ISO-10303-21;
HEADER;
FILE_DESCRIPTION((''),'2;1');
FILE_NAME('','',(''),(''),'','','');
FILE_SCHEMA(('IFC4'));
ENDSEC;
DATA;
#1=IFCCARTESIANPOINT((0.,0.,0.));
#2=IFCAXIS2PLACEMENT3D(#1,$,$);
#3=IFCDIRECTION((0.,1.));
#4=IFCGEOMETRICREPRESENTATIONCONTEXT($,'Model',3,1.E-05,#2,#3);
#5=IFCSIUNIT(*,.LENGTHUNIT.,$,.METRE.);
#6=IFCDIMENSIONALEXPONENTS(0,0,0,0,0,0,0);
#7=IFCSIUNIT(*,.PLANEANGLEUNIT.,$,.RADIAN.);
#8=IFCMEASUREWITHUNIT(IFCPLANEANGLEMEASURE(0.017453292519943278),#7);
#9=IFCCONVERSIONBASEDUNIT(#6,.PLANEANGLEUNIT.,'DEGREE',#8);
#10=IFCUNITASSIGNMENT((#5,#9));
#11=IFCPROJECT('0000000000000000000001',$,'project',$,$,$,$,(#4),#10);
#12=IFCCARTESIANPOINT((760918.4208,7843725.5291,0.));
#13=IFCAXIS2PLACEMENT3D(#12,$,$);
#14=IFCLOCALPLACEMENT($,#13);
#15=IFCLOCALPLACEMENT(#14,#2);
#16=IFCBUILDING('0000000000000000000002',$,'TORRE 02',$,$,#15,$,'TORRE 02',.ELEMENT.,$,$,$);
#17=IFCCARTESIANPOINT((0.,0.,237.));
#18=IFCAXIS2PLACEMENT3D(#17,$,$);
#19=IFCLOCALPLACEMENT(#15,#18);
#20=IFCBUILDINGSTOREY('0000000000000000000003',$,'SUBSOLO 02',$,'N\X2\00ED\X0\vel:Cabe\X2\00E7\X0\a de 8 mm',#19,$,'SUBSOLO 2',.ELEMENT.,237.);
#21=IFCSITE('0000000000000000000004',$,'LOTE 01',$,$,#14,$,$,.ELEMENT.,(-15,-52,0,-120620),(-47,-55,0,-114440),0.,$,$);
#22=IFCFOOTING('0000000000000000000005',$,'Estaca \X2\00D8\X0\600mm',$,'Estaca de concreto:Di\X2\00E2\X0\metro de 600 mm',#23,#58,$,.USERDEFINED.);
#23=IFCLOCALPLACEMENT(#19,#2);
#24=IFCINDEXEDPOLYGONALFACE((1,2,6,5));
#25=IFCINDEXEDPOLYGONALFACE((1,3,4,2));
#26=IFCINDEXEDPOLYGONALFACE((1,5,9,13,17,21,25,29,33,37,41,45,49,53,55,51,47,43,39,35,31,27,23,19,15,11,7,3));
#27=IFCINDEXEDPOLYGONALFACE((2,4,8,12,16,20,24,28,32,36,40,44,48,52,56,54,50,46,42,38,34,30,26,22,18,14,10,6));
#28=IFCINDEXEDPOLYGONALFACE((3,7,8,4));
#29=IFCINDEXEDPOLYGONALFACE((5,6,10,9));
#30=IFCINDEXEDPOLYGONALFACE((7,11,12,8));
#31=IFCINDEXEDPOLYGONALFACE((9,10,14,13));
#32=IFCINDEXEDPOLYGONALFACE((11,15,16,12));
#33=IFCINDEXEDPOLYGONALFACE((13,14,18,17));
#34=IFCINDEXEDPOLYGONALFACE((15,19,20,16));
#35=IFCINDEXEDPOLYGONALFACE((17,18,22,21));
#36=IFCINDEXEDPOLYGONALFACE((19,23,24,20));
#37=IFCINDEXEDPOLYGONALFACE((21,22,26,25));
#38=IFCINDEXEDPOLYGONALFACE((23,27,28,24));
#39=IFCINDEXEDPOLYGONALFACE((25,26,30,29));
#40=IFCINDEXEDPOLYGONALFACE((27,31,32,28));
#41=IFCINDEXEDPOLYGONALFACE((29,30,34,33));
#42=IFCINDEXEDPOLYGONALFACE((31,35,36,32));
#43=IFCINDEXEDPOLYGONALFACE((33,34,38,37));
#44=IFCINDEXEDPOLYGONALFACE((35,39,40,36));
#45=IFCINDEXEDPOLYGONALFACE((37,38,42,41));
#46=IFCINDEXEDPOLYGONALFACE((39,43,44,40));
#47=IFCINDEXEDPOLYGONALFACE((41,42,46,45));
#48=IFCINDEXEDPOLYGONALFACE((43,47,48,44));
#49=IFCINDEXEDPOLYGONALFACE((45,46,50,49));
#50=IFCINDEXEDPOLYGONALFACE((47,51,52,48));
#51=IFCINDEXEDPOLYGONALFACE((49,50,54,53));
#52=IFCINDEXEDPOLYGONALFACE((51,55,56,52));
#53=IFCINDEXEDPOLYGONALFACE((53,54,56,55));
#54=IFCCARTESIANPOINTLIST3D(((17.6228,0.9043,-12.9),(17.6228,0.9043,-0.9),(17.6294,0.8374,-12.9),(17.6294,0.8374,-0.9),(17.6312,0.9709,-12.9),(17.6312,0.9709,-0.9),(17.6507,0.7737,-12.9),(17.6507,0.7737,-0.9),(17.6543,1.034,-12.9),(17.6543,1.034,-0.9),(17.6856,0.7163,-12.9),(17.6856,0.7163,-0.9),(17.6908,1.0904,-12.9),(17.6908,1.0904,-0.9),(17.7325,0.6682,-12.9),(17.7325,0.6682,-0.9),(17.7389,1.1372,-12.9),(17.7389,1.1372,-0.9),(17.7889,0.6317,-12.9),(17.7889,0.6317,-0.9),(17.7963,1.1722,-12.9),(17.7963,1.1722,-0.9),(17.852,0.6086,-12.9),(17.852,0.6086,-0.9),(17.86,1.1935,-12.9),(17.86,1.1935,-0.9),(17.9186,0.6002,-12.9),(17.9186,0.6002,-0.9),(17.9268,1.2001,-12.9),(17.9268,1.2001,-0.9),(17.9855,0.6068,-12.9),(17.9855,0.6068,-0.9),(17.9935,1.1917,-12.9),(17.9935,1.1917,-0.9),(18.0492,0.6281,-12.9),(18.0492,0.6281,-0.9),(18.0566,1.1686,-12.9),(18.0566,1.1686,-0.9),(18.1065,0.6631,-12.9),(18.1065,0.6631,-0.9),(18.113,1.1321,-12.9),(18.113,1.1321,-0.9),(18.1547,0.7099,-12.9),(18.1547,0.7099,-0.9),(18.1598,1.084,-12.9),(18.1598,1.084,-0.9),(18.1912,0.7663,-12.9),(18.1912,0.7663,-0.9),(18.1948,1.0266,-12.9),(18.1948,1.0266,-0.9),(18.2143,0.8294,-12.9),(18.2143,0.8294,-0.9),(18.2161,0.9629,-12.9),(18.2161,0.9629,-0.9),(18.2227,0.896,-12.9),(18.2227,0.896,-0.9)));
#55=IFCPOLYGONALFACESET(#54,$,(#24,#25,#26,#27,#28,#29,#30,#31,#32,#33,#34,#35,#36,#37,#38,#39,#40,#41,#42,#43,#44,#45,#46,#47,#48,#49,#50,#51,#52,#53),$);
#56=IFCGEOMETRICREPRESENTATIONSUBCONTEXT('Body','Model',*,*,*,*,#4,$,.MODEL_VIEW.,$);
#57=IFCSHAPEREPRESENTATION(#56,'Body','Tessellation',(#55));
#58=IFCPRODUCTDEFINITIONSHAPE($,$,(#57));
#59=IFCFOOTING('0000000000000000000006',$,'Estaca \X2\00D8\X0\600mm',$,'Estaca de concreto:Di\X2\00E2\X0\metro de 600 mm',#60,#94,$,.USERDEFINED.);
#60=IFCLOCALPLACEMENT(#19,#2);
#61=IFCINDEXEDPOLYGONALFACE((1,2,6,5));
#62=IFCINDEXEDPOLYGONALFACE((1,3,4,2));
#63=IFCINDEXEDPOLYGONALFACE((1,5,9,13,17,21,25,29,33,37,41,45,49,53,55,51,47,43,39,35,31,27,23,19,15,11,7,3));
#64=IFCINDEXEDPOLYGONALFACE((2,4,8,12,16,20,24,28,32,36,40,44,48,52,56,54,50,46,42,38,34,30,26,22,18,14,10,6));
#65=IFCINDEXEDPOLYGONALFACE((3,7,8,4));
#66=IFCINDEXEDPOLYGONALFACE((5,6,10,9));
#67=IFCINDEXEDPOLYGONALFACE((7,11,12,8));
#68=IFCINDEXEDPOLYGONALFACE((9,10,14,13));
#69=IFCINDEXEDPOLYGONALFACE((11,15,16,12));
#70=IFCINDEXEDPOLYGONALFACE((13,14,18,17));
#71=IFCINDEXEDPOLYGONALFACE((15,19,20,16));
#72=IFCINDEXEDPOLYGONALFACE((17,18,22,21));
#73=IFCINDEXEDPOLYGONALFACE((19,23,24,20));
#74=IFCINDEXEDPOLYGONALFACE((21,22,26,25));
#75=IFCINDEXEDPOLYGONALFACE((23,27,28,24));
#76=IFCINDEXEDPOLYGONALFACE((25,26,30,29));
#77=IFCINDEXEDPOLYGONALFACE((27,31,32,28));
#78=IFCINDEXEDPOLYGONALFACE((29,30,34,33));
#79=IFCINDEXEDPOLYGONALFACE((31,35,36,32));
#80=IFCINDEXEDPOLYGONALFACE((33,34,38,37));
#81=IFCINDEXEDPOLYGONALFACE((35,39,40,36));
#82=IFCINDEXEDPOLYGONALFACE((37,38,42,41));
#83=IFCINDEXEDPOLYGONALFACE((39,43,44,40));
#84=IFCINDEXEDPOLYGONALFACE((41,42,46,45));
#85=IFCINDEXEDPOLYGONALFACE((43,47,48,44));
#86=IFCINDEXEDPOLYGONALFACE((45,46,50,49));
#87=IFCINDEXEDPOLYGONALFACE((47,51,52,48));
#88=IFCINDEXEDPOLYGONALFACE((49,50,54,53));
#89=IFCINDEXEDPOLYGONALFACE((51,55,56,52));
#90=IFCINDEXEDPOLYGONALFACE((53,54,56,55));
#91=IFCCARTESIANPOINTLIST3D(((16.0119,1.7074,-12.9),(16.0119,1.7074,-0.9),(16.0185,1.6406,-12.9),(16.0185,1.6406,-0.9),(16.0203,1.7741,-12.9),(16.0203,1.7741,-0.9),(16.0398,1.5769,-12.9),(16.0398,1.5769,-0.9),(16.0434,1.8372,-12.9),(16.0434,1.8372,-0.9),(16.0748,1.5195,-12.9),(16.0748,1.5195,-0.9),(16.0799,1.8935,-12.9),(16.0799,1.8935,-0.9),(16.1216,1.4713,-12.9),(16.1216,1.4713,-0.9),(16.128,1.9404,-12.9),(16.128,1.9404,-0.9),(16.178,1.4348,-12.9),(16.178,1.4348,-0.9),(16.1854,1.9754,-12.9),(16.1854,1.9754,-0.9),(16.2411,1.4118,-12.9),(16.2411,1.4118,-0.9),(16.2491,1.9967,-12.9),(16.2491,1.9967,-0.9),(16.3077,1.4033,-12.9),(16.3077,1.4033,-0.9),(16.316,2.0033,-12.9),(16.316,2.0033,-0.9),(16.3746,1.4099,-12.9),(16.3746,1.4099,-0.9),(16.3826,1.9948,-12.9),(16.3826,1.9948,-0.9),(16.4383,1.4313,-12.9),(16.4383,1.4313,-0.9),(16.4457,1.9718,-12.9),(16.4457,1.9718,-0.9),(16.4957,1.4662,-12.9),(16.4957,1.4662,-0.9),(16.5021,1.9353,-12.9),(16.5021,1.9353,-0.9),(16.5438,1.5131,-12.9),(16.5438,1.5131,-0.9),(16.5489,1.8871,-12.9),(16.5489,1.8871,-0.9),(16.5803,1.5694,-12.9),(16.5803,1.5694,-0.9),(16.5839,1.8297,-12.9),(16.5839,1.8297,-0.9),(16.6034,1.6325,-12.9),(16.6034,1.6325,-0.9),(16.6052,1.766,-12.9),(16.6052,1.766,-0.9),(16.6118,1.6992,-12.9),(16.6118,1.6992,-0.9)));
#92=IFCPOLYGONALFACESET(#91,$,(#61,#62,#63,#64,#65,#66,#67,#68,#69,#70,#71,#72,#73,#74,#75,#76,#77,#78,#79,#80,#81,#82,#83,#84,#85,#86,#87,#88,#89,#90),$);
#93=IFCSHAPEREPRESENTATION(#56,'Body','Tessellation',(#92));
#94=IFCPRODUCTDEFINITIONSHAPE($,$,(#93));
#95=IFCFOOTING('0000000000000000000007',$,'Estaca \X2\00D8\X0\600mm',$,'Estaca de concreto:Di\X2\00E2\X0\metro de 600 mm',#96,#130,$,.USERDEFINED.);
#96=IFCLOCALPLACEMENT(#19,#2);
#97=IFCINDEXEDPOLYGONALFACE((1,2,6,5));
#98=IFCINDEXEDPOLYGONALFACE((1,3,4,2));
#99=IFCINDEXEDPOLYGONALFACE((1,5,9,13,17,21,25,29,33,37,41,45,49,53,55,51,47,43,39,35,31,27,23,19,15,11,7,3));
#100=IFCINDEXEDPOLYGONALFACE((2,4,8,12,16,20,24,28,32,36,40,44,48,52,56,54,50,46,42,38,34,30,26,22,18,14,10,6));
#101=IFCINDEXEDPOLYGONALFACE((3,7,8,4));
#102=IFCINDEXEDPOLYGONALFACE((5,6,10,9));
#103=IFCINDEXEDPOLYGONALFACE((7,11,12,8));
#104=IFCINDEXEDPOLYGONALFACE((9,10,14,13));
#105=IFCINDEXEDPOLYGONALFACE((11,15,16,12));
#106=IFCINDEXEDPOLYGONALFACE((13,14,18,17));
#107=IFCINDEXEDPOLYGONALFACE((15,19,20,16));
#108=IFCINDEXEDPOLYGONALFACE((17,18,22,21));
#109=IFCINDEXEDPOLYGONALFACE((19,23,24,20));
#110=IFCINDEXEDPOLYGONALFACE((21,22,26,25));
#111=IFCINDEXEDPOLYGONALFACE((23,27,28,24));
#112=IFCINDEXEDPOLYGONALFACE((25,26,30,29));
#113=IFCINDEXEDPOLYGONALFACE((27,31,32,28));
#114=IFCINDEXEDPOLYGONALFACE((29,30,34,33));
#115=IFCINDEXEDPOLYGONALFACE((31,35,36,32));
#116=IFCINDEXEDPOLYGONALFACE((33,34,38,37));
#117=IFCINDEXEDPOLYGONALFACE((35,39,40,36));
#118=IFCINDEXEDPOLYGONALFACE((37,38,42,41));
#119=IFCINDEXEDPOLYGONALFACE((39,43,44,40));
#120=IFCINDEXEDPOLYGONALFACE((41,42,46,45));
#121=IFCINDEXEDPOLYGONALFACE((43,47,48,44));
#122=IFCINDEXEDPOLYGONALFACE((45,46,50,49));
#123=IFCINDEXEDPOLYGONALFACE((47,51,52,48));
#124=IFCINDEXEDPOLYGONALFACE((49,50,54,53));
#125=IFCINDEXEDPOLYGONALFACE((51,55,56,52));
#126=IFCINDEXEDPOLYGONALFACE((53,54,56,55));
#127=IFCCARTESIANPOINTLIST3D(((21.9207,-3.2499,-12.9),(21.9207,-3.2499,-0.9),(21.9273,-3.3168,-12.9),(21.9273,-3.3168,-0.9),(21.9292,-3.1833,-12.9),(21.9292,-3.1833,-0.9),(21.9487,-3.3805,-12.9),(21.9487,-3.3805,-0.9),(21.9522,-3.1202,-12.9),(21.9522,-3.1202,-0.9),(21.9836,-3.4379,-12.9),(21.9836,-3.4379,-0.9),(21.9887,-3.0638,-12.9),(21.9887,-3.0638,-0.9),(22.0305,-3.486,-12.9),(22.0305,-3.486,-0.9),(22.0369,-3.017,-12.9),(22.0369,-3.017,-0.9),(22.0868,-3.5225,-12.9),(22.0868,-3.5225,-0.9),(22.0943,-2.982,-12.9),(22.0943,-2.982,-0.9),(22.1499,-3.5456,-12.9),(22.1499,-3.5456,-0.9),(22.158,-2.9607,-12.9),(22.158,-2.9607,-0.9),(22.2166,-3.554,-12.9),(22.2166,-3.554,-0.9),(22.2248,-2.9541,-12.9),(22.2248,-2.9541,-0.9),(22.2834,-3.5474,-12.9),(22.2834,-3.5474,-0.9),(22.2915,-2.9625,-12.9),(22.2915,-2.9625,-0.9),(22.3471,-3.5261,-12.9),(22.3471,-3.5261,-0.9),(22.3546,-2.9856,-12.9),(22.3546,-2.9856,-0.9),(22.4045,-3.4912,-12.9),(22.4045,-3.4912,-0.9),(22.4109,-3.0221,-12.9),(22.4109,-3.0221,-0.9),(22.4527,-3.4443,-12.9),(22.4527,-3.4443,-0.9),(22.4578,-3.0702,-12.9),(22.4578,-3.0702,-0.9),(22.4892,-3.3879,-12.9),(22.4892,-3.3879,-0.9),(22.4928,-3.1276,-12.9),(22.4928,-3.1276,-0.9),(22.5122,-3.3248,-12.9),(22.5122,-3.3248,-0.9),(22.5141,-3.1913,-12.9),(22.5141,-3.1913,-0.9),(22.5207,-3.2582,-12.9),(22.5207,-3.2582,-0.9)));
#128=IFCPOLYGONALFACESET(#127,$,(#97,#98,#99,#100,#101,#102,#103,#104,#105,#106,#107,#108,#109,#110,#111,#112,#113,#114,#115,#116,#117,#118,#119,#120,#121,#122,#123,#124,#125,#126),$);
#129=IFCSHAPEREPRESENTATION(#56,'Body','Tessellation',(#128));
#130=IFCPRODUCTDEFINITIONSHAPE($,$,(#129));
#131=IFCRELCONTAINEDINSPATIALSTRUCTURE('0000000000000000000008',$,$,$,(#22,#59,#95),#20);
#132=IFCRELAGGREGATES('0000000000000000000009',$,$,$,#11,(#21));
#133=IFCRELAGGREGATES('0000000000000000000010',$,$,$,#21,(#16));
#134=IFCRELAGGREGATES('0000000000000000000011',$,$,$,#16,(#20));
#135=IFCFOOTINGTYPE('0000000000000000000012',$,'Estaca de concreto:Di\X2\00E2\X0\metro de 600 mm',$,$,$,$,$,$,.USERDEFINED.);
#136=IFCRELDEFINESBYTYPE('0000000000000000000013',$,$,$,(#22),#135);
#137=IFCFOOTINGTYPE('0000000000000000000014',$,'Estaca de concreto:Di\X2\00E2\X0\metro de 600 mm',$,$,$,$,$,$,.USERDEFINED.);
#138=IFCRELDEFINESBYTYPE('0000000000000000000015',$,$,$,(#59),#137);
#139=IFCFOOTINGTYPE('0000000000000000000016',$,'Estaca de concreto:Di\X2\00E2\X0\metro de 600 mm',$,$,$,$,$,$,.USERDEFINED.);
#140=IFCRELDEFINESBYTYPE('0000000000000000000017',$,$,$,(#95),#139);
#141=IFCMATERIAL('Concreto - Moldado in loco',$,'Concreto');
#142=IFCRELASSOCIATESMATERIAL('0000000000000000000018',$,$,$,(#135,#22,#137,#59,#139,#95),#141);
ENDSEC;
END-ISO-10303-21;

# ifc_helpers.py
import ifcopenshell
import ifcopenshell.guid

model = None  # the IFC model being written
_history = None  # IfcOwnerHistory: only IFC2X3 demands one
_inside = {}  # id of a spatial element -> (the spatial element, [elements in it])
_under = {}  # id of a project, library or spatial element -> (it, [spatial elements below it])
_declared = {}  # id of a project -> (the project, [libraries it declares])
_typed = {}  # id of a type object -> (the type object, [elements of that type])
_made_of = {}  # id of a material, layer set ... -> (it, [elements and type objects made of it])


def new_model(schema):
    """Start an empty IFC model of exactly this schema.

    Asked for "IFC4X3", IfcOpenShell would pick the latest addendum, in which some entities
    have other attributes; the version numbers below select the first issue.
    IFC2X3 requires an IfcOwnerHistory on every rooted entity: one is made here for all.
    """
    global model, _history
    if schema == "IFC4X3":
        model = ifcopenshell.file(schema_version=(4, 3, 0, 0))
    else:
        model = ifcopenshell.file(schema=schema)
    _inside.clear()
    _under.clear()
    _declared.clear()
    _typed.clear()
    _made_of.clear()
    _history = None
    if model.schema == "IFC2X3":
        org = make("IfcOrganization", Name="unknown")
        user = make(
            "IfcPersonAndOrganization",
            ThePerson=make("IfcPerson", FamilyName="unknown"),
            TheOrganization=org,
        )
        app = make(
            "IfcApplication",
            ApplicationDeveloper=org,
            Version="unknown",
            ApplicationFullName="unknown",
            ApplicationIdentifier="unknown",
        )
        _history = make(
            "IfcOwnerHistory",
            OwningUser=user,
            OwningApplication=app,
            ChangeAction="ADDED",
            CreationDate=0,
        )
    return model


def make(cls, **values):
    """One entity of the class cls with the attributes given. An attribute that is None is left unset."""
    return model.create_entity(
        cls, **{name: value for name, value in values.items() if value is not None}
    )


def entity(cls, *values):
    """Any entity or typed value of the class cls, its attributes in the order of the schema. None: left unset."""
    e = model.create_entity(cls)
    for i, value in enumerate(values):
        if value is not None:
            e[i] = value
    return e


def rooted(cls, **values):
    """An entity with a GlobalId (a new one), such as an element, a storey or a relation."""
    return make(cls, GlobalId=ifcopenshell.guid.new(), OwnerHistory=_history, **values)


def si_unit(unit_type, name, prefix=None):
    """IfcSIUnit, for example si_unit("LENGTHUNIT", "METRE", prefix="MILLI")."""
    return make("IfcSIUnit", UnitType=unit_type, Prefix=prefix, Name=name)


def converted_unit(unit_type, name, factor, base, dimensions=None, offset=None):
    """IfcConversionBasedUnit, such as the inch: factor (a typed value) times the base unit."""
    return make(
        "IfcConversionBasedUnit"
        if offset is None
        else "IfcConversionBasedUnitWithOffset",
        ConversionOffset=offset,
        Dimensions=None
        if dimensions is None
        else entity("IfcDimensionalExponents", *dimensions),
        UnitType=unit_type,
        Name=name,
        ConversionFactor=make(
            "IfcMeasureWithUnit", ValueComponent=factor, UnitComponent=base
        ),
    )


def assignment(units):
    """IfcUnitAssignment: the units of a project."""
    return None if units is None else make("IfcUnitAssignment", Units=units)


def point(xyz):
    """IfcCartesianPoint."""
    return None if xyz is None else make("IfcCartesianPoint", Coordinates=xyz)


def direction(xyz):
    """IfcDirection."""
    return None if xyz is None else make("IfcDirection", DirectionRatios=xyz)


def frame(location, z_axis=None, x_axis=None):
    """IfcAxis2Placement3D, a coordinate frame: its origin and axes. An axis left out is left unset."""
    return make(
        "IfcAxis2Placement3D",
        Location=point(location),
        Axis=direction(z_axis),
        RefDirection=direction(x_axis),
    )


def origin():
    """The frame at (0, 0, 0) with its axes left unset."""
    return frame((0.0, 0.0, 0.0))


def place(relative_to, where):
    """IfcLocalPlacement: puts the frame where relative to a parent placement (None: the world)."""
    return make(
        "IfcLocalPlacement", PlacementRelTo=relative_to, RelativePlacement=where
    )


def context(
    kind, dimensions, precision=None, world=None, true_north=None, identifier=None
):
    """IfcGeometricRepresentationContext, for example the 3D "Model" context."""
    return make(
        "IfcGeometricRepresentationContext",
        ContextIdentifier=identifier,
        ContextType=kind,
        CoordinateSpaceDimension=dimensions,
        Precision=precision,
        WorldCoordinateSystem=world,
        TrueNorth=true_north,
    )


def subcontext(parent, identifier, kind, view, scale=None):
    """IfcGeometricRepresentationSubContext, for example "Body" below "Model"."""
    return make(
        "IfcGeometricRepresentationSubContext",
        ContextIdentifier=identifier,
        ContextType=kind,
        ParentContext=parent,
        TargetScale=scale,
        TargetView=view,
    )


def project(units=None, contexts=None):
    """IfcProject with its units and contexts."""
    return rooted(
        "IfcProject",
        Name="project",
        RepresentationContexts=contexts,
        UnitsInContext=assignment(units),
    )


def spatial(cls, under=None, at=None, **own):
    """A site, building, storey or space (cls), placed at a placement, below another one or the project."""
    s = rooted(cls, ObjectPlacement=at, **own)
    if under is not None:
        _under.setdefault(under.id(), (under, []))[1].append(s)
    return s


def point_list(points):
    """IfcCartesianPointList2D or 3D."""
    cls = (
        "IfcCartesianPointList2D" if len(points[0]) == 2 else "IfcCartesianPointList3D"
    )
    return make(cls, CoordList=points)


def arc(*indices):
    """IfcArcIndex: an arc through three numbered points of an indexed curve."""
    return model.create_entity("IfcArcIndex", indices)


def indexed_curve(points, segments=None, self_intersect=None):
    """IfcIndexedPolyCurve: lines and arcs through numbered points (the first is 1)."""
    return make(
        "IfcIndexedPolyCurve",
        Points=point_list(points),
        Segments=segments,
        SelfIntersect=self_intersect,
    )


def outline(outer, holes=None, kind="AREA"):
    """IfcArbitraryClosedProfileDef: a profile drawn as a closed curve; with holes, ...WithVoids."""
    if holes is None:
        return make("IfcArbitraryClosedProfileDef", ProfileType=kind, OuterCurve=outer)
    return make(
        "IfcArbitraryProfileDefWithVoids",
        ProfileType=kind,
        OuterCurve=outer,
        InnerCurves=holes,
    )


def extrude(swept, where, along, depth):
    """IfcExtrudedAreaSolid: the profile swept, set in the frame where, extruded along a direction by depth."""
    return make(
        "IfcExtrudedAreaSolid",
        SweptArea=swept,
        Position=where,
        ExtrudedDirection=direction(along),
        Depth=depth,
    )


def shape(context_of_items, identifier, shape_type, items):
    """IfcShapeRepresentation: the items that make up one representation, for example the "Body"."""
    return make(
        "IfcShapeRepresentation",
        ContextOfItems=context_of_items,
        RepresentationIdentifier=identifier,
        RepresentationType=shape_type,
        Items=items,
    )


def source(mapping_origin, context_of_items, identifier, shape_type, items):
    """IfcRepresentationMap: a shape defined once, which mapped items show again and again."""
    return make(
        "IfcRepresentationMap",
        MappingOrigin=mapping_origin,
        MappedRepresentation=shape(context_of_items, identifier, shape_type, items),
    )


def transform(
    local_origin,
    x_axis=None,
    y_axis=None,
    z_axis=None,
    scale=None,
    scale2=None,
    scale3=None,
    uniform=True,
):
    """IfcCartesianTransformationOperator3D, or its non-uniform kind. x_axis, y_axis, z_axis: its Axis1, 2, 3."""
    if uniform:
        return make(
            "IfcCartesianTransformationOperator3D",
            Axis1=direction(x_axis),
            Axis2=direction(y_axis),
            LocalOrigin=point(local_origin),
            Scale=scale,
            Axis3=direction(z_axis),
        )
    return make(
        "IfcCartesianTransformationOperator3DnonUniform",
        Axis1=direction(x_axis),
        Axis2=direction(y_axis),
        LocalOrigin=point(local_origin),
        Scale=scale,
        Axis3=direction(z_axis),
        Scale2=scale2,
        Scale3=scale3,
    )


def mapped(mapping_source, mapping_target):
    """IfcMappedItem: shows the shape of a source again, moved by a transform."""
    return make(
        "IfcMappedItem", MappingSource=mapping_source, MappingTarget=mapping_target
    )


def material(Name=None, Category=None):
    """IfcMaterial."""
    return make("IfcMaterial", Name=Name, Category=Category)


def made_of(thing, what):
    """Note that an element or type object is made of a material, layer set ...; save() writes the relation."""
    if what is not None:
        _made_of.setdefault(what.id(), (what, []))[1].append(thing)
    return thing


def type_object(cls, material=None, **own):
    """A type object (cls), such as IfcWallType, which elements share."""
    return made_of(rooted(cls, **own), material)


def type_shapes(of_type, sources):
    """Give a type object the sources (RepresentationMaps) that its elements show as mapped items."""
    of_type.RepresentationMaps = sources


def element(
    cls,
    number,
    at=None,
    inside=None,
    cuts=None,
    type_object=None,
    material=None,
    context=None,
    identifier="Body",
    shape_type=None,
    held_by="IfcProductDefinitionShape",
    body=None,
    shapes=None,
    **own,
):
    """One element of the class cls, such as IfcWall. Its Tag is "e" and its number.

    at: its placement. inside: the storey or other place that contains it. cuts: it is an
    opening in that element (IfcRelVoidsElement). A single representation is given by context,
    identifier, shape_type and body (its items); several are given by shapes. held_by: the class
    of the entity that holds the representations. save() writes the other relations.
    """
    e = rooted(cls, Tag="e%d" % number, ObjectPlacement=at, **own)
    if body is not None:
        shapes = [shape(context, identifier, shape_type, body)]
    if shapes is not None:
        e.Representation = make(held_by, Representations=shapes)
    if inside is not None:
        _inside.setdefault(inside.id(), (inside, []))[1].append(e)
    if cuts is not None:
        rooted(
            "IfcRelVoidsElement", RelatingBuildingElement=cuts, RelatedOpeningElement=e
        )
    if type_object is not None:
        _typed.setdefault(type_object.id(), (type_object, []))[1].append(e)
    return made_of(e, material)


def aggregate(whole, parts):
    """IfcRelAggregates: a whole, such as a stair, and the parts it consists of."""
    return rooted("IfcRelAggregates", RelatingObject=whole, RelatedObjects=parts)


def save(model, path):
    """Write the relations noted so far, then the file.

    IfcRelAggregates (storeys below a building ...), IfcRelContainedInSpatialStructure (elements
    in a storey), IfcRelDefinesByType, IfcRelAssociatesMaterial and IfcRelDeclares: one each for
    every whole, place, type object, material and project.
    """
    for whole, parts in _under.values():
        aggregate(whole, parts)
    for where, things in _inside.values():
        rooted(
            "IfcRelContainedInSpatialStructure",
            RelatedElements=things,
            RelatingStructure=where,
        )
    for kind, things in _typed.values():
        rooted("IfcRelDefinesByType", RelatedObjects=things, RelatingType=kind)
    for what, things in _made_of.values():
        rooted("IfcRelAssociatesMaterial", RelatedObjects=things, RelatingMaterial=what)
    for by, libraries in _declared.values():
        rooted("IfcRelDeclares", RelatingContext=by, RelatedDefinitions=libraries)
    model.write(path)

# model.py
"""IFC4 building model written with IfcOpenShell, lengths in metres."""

from ifc_helpers import new_model, entity, si_unit, converted_unit, direction, frame, origin, place, context, subcontext, project, spatial, arc, indexed_curve, outline, extrude, source, transform, mapped, material, type_object, type_shapes, element, save


model = new_model("IFC4")

# Units and contexts
model_context = context("Model", 3, precision=1e-05, world=origin(), true_north=direction((0.0, 1.0)))
body_context = subcontext(model_context, "Body", "Model", "MODEL_VIEW")
ifc_project = project(units=[si_unit("LENGTHUNIT", "METRE"), converted_unit("PLANEANGLEUNIT", "DEGREE", entity("IfcPlaneAngleMeasure", 0.017453292519943278), si_unit("PLANEANGLEUNIT", "RADIAN"), dimensions=[0, 0, 0, 0, 0, 0, 0])], contexts=[model_context])

# Site, building, storey
site_placement = place(None, frame((760918.4208, 7843725.5291, 0.0)))
site = spatial("IfcSite", under=ifc_project, at=site_placement, Name="LOTE 01", CompositionType="ELEMENT", RefLatitude=(-15, -52, 0, -120620), RefLongitude=(-47, -55, 0, -114440), RefElevation=0.0)
building_placement = place(site_placement, origin())
building = spatial("IfcBuilding", under=site, at=building_placement, Name="TORRE 02", LongName="TORRE 02", CompositionType="ELEMENT")
storey_placement = place(building_placement, frame((0.0, 0.0, 237.0)))
storey = spatial("IfcBuildingStorey", under=building, at=storey_placement, Name="SUBSOLO 02", ObjectType="Nível:Cabeça de 8 mm", LongName="SUBSOLO 2", CompositionType="ELEMENT", Elevation=237.0)

# Footings
ifc_material = material(Name="Concreto - Moldado in loco", Category="Concreto")
placement = place(building_placement, frame((0.0, 0.0, 237.0)))
footing_type_1 = type_object("IfcFootingType", Name="Estaca de concreto:Diâmetro de 600 mm", PredefinedType="USERDEFINED", material=ifc_material)
shared_shape_1 = source(origin(), body_context, "Body", "SweptSolid", [
    extrude(outline(indexed_curve([(-0.3, 0.0), (0.0, -0.3), (0.3, 0.0), (0.0, 0.3)], segments=[arc(1, 2, 3), arc(3, 4, 1)], self_intersect=False)), frame((17.9227, 0.9001, -12.0), z_axis=(0.0, 0.0, 1.0), x_axis=(0.894934, -0.446198, 0.0)), (0.0, 0.0, 1.0), 12.0),
])
type_shapes(footing_type_1, [shared_shape_1])
footing_1_placement = place(placement, frame((0.0, 0.0, -0.9)))
element("IfcFooting", 1, at=footing_1_placement, inside=storey, type_object=footing_type_1, material=ifc_material, Name="Estaca Ø600mm", ObjectType="Estaca de concreto:Diâmetro de 600 mm", PredefinedType="USERDEFINED", context=body_context, shape_type="MappedRepresentation", body=[
    mapped(shared_shape_1, transform((0.0, 0.0, 0.0), scale=1.0)),
])
footing_type_2 = type_object("IfcFootingType", Name="Estaca de concreto:Diâmetro de 600 mm", PredefinedType="USERDEFINED", material=ifc_material)
shared_shape_2 = source(origin(), body_context, "Body", "SweptSolid", [
    extrude(outline(indexed_curve([(-0.3, 0.0), (0.0, -0.3), (0.3, 0.0), (0.0, 0.3)], segments=[arc(1, 2, 3), arc(3, 4, 1)], self_intersect=False)), frame((16.3119, 1.7033, -12.0), z_axis=(0.0, 0.0, 1.0), x_axis=(0.894934, -0.446198, 0.0)), (0.0, 0.0, 1.0), 12.0),
])
type_shapes(footing_type_2, [shared_shape_2])
footing_2_placement = place(placement, frame((0.0, 0.0, -0.9)))
element("IfcFooting", 2, at=footing_2_placement, inside=storey, type_object=footing_type_2, material=ifc_material, Name="Estaca Ø600mm", ObjectType="Estaca de concreto:Diâmetro de 600 mm", PredefinedType="USERDEFINED", context=body_context, shape_type="MappedRepresentation", body=[
    mapped(shared_shape_2, transform((0.0, 0.0, 0.0), scale=1.0)),
])
footing_type_3 = type_object("IfcFootingType", Name="Estaca de concreto:Diâmetro de 600 mm", PredefinedType="USERDEFINED", material=ifc_material)
shared_shape_3 = source(origin(), body_context, "Body", "SweptSolid", [
    extrude(outline(indexed_curve([(-0.3, 0.0), (0.0, -0.3), (0.3, 0.0), (0.0, 0.3)], segments=[arc(1, 2, 3), arc(3, 4, 1)], self_intersect=False)), frame((22.2207, -3.2541, -12.0), z_axis=(0.0, 0.0, 1.0), x_axis=(0.894934, -0.446198, 0.0)), (0.0, 0.0, 1.0), 12.0),
])
type_shapes(footing_type_3, [shared_shape_3])
footing_3_placement = place(placement, frame((0.0, 0.0, -0.9)))
element("IfcFooting", 3, at=footing_3_placement, inside=storey, type_object=footing_type_3, material=ifc_material, Name="Estaca Ø600mm", ObjectType="Estaca de concreto:Diâmetro de 600 mm", PredefinedType="USERDEFINED", context=body_context, shape_type="MappedRepresentation", body=[
    mapped(shared_shape_3, transform((0.0, 0.0, 0.0), scale=1.0)),
])

save(model, "model.ifc")
